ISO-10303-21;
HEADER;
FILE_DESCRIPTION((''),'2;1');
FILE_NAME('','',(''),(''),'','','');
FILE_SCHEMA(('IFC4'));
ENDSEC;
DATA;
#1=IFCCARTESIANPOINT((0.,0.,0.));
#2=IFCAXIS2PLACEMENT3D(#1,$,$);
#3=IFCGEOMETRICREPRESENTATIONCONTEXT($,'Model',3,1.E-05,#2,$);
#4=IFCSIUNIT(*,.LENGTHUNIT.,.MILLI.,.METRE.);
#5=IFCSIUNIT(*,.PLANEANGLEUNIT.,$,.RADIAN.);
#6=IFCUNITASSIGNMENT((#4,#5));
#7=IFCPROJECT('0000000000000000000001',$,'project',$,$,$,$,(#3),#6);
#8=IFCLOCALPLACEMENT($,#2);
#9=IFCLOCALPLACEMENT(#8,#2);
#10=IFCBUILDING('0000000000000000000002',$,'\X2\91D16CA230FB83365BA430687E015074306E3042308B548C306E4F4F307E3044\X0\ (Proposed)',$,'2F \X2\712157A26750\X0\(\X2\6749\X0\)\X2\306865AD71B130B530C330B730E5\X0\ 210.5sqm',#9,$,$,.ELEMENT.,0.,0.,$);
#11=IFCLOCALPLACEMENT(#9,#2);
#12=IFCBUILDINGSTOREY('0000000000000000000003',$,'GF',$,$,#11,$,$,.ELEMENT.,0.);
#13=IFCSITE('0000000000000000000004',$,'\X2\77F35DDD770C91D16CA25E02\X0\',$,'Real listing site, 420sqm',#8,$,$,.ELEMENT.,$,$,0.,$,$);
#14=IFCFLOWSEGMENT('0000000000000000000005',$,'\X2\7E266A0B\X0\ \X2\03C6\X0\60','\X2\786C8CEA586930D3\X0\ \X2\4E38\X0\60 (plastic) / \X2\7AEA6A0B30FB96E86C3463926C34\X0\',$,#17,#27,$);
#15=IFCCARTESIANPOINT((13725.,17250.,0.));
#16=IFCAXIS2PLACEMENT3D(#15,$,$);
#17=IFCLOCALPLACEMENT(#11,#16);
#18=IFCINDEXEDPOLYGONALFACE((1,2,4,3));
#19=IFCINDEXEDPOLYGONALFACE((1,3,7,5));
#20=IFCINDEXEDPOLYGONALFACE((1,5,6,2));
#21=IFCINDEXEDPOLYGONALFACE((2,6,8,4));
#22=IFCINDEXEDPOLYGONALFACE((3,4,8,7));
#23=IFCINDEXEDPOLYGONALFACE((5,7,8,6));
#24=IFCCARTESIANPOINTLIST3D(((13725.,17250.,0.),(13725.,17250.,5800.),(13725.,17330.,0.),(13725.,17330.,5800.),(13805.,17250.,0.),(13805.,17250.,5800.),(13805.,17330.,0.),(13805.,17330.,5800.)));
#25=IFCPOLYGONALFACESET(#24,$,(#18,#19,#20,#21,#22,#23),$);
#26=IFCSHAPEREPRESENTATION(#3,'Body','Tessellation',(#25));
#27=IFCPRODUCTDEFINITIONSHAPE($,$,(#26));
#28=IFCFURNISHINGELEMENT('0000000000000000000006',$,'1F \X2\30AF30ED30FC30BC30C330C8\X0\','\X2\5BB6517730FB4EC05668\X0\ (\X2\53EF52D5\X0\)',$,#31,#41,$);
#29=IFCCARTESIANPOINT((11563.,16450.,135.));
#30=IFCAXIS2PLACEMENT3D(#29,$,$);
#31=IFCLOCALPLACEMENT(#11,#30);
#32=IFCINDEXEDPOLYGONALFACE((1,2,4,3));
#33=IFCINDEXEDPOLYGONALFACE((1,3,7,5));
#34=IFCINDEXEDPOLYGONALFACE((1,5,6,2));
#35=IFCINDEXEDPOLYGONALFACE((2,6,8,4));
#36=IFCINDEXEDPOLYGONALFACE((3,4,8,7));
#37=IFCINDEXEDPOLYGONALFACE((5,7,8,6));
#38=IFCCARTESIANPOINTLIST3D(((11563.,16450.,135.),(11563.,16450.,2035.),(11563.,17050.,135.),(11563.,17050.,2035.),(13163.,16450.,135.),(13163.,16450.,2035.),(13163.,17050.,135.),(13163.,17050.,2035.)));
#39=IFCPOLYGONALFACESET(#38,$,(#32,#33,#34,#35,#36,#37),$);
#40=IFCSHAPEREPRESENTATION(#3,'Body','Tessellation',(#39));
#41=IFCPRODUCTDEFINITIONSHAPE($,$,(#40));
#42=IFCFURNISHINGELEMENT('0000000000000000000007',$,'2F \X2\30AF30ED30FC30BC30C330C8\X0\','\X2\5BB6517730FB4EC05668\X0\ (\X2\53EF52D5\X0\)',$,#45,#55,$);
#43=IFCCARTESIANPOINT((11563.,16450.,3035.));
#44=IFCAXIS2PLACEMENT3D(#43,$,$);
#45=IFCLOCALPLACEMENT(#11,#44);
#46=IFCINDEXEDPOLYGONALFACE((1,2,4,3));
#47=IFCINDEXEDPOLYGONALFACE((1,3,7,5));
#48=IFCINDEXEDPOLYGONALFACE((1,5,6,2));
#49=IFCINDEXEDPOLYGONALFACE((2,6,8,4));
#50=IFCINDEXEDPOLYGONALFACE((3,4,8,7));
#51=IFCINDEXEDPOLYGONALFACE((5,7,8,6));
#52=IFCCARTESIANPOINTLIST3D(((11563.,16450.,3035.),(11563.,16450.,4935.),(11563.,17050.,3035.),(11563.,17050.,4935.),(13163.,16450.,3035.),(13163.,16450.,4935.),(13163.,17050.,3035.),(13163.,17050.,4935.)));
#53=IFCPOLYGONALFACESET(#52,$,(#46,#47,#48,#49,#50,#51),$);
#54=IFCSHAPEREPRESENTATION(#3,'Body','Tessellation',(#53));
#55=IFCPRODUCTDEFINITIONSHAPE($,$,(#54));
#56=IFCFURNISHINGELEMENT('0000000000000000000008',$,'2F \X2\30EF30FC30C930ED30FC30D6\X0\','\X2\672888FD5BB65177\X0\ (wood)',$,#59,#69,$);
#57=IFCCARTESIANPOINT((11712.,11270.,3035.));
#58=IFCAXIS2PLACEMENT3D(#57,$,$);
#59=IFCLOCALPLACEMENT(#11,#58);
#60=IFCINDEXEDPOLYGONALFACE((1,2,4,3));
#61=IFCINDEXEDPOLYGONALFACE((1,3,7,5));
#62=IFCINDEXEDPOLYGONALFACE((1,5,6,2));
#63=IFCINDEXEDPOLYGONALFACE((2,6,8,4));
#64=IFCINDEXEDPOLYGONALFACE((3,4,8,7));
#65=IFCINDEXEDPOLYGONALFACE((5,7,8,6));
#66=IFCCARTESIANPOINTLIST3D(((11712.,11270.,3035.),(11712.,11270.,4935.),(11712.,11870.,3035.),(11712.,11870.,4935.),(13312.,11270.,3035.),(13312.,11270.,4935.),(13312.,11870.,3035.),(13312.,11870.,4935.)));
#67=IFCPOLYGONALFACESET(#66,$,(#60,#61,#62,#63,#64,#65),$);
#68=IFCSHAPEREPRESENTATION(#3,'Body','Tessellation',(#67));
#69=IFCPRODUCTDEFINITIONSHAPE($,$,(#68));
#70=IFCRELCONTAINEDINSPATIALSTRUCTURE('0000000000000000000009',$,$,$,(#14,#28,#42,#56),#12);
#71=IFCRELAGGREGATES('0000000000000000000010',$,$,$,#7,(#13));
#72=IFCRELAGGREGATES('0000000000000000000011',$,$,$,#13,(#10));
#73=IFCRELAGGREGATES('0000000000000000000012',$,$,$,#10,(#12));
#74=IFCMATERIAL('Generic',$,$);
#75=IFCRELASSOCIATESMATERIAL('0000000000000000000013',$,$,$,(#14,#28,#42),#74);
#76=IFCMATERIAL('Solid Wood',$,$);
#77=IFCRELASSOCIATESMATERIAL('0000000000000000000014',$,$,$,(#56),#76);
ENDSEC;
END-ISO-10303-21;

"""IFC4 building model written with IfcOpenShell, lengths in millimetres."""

from ifc_helpers import new_model, si_unit, frame, frame_2d, origin, place, context, project, spatial, rectangle, extrude, material, element, save


model = new_model("IFC4")

# Units and contexts
model_context = context("Model", 3, precision=1e-05, world=origin())
ifc_project = project(units=[si_unit("LENGTHUNIT", "METRE", prefix="MILLI"), si_unit("PLANEANGLEUNIT", "RADIAN")], contexts=[model_context])

# Site, building, storey
site_placement = place(None, origin())
site = spatial("IfcSite", under=ifc_project, at=site_placement, Name="石川県金沢市", ObjectType="Real listing site, 420sqm", CompositionType="ELEMENT", RefElevation=0.0)
building_placement = place(site_placement, origin())
building = spatial("IfcBuilding", under=site, at=building_placement, Name="金沢・茶室と縁側のある和の住まい (Proposed)", ObjectType="2F 無垢材(杉)と断熱サッシュ 210.5sqm", CompositionType="ELEMENT", ElevationOfRefHeight=0.0, ElevationOfTerrain=0.0)
storey_placement = place(building_placement, origin())
storey = spatial("IfcBuildingStorey", under=building, at=storey_placement, Name="GF", CompositionType="ELEMENT", Elevation=0.0)

# Shared definitions
ifc_material_1 = material(Name="Solid Wood")

# Shared definitions
ifc_material_2 = material(Name="Generic")

# Flow segment
flow_segment_placement = place(storey_placement, frame((13725.0, 17250.0, 0.0)))
element("IfcFlowSegment", 1, at=flow_segment_placement, inside=storey, material=ifc_material_2, Name="縦樋 φ60", Description="硬質塩ビ 丸60 (plastic) / 竪樋・雨水排水", context=model_context, shape_type="SweptSolid", body=[
    extrude(rectangle(XDim=80.0, YDim=80.0, at=frame_2d((40.0, 40.0))), frame((13725.0, 17250.0, 0.0)), (0.0, 0.0, 1.0), 5800.0),
])

# Furnishing elements
furnishing_1_placement = place(storey_placement, frame((11563.0, 16450.0, 135.0)))
element("IfcFurnishingElement", 2, at=furnishing_1_placement, inside=storey, material=ifc_material_2, Name="1F クローゼット", Description="家具・什器 (可動)", context=model_context, shape_type="SweptSolid", body=[
    extrude(rectangle(XDim=1600.0, YDim=600.0, at=frame_2d((800.0, 300.0))), frame((11563.0, 16450.0, 135.0)), (0.0, 0.0, 1.0), 1900.0),
])
furnishing_2_placement = place(storey_placement, frame((11563.0, 16450.0, 3035.0)))
element("IfcFurnishingElement", 3, at=furnishing_2_placement, inside=storey, material=ifc_material_2, Name="2F クローゼット", Description="家具・什器 (可動)", context=model_context, shape_type="SweptSolid", body=[
    extrude(rectangle(XDim=1600.0, YDim=600.0, at=frame_2d((800.0, 300.0))), frame((11563.0, 16450.0, 3035.0)), (0.0, 0.0, 1.0), 1900.0),
])
furnishing_3_placement = place(storey_placement, frame((11712.0, 11270.0, 3035.0)))
element("IfcFurnishingElement", 4, at=furnishing_3_placement, inside=storey, material=ifc_material_1, Name="2F ワードローブ", Description="木製家具 (wood)", context=model_context, shape_type="SweptSolid", body=[
    extrude(rectangle(XDim=1600.0, YDim=600.0, at=frame_2d((800.0, 300.0))), frame((11712.0, 11270.0, 3035.0)), (0.0, 0.0, 1.0), 1900.0),
])

save(model, "model.ifc")
